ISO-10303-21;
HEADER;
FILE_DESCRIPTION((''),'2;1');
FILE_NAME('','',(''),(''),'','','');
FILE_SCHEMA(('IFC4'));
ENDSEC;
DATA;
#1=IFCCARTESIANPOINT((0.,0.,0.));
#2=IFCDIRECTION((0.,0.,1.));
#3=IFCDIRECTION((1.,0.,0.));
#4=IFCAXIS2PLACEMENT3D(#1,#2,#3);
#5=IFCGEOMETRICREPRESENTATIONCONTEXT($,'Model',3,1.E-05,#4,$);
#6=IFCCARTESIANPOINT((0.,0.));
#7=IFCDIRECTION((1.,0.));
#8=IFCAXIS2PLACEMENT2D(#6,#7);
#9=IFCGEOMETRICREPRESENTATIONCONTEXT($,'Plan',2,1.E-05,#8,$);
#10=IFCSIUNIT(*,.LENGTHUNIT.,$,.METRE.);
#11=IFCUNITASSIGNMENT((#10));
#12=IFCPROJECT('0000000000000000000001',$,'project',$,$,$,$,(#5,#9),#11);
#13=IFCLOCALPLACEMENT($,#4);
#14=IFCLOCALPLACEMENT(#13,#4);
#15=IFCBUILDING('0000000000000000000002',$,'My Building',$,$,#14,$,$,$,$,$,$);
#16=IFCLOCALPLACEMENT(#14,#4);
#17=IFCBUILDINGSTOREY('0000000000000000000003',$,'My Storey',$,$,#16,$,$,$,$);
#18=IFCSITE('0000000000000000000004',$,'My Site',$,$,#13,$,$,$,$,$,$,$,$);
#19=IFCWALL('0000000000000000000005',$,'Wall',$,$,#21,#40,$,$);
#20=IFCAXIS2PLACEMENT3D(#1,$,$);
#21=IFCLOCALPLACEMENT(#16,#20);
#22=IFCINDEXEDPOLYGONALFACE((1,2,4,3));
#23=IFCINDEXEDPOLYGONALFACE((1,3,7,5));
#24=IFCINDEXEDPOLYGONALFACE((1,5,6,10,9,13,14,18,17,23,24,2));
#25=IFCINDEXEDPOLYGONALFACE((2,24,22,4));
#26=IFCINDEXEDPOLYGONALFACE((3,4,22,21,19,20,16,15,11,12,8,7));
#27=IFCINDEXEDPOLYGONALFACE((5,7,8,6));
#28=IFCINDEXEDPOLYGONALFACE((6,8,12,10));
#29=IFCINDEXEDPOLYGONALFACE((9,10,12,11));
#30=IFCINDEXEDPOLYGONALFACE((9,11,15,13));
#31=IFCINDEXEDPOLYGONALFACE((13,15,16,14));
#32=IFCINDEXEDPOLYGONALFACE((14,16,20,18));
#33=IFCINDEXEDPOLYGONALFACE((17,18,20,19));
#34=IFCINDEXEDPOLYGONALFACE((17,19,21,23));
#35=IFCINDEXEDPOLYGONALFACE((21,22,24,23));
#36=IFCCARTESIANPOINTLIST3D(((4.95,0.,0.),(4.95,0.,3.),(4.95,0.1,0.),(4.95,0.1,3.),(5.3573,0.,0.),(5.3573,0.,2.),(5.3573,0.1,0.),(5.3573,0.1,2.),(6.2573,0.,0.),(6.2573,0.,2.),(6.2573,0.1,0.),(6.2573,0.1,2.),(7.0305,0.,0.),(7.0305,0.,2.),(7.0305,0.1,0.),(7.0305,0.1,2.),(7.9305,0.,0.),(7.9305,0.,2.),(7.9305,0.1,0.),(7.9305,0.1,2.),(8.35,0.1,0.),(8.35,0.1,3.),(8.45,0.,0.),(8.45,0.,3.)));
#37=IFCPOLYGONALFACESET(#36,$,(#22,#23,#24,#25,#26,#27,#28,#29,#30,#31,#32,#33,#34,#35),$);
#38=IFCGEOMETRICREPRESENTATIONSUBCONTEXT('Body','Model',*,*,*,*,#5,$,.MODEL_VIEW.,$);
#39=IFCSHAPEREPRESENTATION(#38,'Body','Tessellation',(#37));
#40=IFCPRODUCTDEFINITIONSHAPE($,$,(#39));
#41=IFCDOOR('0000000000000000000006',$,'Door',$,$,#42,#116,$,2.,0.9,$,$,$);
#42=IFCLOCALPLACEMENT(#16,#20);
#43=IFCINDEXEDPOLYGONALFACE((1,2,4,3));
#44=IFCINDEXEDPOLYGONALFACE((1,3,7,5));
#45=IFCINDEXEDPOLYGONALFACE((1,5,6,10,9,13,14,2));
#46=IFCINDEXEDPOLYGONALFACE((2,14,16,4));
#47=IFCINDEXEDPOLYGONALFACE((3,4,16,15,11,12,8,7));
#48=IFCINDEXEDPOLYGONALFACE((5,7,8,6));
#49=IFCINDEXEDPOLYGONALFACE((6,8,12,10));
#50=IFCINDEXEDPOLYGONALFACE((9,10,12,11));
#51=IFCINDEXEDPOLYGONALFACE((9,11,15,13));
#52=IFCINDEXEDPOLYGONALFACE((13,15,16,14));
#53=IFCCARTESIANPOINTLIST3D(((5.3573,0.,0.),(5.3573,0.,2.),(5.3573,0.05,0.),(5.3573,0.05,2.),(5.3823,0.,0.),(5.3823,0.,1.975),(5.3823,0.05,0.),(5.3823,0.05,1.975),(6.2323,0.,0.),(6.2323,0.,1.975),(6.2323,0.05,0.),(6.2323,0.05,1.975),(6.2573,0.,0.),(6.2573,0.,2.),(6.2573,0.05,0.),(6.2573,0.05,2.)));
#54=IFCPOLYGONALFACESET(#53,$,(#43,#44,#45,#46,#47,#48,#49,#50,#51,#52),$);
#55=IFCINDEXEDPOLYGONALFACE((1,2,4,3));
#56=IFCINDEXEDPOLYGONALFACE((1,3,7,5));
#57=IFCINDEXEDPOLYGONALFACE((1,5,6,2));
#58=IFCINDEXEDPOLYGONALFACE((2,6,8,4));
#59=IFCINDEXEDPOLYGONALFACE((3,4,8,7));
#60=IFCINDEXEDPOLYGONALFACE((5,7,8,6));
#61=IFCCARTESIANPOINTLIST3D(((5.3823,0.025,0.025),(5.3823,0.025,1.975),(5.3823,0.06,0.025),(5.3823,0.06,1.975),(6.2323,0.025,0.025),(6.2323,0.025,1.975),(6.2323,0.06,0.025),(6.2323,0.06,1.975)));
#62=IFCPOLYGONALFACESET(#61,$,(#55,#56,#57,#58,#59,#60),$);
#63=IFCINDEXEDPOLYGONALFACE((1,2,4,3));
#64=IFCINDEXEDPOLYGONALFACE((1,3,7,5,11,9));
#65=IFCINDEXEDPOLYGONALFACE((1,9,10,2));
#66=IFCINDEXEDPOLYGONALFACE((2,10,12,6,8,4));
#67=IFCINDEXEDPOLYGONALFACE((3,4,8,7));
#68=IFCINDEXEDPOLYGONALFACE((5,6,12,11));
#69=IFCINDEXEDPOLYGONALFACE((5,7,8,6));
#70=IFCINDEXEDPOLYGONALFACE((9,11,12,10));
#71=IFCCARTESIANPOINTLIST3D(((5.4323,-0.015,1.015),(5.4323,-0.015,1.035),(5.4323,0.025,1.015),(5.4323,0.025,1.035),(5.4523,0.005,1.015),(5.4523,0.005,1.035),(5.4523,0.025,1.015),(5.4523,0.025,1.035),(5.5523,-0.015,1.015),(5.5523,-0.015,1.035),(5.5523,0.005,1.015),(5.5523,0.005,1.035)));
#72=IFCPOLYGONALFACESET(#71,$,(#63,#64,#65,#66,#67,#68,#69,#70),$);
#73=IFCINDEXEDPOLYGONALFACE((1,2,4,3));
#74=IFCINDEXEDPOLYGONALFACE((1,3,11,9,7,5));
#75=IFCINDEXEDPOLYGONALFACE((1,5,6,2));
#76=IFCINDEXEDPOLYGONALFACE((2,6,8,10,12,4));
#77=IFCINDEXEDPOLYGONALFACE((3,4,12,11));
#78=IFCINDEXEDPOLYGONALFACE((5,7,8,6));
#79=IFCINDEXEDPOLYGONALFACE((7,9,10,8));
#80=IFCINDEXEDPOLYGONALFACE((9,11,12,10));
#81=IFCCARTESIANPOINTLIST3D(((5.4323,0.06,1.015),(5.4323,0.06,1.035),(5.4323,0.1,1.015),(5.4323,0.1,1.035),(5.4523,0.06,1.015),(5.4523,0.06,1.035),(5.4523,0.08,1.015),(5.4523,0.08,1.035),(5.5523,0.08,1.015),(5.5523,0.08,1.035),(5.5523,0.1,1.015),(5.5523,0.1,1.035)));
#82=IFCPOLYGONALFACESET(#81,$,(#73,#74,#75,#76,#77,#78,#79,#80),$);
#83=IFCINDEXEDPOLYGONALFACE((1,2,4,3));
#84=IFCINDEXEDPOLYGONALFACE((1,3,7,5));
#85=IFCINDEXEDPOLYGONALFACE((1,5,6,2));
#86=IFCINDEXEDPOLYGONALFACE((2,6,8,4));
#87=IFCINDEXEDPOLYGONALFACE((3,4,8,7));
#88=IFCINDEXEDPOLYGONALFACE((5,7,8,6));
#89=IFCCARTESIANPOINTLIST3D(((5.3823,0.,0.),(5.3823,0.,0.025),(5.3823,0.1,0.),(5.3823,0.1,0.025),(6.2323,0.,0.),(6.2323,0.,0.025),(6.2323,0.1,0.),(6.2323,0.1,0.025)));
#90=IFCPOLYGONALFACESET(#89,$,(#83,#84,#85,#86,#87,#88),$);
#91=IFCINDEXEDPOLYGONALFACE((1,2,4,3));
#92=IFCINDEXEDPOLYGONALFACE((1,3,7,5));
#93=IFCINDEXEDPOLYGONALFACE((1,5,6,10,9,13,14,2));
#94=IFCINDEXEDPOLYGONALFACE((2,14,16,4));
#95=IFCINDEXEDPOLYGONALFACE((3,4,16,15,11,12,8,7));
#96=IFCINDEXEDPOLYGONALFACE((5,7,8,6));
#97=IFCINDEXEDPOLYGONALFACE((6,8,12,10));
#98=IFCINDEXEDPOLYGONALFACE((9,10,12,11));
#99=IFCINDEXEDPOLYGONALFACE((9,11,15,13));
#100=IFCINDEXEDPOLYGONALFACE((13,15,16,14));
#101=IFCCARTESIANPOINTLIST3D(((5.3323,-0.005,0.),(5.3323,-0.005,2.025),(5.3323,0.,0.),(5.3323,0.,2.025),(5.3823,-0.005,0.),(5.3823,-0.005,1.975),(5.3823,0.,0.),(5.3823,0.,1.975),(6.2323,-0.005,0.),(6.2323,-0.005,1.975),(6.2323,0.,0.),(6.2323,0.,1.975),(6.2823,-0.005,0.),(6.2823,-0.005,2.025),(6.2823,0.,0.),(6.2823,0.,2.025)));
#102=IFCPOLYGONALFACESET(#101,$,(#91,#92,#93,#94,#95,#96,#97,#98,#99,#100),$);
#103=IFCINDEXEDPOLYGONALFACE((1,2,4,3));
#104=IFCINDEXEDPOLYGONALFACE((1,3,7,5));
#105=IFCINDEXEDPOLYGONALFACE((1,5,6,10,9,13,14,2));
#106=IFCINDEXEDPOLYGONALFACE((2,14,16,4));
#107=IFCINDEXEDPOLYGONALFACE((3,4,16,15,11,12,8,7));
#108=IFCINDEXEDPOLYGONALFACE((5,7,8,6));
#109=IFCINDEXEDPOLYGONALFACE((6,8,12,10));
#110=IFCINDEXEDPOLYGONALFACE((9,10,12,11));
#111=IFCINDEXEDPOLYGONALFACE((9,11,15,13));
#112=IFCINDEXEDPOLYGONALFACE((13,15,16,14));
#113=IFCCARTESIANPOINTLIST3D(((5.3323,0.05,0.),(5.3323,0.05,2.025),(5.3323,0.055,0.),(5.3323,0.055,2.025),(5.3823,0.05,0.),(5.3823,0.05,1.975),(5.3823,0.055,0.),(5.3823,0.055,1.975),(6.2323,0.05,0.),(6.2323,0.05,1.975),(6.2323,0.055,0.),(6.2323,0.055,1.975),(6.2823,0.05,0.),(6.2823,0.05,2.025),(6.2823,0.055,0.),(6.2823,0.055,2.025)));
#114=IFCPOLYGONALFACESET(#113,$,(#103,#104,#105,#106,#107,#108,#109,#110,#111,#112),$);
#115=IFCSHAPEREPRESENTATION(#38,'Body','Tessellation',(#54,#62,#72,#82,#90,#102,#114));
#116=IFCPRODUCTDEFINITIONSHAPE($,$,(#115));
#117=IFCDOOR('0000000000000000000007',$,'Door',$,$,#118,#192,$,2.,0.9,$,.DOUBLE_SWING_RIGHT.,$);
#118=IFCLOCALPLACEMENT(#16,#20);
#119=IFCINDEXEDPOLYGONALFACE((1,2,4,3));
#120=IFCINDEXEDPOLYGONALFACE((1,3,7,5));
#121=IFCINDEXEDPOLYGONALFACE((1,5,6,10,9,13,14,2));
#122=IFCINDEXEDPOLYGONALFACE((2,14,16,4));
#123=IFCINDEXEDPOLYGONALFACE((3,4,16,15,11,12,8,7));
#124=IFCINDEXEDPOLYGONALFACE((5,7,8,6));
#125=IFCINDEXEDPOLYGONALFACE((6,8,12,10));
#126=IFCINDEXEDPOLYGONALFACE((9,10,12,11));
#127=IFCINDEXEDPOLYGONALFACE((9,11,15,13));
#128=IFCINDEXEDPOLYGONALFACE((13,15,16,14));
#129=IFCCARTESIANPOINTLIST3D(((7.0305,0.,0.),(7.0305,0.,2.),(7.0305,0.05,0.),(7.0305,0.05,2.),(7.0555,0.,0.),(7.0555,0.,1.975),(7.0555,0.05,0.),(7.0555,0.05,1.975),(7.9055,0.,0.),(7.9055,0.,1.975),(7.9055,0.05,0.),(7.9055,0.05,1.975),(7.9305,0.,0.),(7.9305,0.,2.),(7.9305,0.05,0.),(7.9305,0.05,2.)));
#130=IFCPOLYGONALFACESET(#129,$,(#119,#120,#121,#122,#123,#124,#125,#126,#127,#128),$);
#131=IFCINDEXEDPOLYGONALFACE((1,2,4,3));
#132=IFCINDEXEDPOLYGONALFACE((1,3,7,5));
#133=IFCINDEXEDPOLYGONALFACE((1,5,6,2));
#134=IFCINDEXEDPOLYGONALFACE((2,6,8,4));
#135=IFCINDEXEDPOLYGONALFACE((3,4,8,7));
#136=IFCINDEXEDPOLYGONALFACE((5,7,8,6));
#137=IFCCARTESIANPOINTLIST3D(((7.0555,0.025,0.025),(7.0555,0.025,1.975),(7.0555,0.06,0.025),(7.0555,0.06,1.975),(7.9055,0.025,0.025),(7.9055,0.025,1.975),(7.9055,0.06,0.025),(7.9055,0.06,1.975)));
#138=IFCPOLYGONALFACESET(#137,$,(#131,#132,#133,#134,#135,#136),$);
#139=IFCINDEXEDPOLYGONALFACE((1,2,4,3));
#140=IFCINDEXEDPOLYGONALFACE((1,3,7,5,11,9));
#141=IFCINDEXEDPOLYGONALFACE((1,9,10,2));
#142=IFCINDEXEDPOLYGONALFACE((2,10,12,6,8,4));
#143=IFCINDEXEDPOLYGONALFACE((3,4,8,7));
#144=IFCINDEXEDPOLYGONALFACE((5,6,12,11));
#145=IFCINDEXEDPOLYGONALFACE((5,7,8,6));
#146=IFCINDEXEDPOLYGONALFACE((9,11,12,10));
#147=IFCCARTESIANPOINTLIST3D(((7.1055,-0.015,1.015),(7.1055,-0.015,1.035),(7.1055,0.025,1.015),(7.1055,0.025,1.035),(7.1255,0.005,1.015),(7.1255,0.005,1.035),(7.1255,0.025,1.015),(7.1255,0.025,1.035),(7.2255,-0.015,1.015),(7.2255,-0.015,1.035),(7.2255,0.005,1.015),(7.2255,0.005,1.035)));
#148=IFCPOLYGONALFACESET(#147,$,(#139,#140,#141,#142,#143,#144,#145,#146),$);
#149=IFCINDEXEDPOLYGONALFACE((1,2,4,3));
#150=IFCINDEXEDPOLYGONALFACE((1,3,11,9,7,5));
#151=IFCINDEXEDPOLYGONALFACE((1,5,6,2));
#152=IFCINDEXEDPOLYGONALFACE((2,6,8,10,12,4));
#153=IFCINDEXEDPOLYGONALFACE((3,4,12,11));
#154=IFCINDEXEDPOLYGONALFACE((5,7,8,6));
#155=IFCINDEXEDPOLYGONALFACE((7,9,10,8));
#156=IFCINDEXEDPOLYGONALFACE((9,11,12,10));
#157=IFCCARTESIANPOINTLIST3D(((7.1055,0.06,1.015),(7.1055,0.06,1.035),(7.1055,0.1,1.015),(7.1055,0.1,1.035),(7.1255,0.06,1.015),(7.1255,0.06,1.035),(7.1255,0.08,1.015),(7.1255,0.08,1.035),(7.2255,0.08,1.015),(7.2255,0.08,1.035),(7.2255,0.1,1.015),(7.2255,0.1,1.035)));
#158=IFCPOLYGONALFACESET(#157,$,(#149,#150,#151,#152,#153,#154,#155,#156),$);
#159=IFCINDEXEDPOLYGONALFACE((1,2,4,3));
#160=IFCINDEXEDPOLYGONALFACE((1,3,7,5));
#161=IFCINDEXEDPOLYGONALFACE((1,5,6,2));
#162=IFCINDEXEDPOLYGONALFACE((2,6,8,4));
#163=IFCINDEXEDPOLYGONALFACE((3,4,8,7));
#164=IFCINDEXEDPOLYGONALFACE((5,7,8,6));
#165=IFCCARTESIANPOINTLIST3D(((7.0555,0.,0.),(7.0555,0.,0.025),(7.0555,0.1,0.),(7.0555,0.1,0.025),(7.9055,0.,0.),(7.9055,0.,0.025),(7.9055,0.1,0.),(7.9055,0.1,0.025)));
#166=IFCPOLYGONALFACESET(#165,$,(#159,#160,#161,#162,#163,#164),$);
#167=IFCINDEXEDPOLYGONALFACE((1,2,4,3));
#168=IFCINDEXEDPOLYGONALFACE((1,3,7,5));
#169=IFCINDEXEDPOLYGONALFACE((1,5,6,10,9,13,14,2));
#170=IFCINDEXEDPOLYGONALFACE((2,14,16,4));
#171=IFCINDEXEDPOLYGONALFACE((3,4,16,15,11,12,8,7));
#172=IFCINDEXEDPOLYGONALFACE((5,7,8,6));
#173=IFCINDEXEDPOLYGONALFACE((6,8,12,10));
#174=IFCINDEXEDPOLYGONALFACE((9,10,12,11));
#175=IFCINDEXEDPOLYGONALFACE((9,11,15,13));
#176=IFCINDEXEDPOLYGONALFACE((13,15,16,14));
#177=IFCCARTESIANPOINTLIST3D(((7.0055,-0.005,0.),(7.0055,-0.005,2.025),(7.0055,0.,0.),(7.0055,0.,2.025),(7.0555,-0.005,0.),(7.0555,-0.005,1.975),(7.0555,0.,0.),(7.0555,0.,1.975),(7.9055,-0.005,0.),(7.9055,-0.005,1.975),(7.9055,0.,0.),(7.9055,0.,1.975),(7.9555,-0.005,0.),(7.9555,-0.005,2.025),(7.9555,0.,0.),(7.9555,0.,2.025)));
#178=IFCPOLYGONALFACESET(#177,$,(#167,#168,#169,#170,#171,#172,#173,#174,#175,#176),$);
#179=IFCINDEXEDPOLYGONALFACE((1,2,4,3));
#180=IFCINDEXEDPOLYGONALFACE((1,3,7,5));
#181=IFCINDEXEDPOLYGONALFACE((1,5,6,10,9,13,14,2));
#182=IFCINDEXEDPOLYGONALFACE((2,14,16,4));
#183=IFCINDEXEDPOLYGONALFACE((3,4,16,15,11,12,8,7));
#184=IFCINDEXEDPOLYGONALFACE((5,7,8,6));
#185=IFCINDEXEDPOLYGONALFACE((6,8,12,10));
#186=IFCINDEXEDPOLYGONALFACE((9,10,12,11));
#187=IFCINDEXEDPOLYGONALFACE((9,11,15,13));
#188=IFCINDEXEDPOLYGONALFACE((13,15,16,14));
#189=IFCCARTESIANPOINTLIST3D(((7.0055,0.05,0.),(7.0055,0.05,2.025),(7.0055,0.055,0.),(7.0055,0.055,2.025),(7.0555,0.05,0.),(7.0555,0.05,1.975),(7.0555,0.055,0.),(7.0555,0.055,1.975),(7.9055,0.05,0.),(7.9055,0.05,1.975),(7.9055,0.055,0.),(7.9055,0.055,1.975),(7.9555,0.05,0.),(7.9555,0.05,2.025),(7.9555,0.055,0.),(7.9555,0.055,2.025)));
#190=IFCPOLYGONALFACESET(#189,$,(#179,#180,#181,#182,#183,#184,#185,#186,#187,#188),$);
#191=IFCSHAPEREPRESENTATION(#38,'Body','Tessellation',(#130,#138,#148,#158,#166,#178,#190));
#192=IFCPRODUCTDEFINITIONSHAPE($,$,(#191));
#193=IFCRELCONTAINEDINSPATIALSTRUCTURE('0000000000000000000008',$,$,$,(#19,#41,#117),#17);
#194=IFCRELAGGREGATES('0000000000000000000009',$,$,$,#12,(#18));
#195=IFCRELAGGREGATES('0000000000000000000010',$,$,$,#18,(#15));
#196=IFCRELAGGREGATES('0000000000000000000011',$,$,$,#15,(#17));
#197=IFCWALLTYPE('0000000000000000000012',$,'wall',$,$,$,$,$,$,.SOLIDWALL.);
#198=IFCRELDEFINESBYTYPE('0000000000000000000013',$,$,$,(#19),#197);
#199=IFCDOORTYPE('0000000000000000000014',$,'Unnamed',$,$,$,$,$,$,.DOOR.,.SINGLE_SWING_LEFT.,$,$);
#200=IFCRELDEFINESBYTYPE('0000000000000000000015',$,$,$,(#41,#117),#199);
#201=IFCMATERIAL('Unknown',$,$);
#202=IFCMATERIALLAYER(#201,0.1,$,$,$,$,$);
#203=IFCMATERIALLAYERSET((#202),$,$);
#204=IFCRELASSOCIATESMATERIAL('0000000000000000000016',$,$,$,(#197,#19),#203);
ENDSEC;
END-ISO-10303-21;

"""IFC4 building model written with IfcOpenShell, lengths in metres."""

from ifc_helpers import new_model, entity, si_unit, frame, origin_with_axes, origin_2d_with_axis, place, context, subcontext, project, spatial, line, indexed_curve, outline, extrude, shape, source, transform, mapped, material, layer, layer_set, layer_usage, type_object, type_shapes, element, fill, save


model = new_model("IFC4")

# Units and contexts
model_context = context("Model", 3, precision=1e-05, world=origin_with_axes())
plan_context = context("Plan", 2, precision=1e-05, world=origin_2d_with_axis())
body_context_1 = subcontext(model_context, "Body", "Model", "MODEL_VIEW")
body_context_2 = subcontext(plan_context, "Body", "Plan", "PLAN_VIEW")
ifc_project = project(units=[si_unit("LENGTHUNIT", "METRE")], contexts=[model_context, plan_context])

# Site, building, storey
site_placement = place(None, origin_with_axes())
site = spatial("IfcSite", under=ifc_project, at=site_placement, Name="My Site")
building_placement = place(site_placement, origin_with_axes())
building = spatial("IfcBuilding", under=site, at=building_placement, Name="My Building")
storey_placement = place(building_placement, origin_with_axes())
storey = spatial("IfcBuildingStorey", under=building, at=storey_placement, Name="My Storey")

# Shared definitions
ifc_material = material(Name="Unknown")

# Shared definitions
ifc_layer_1 = layer(ifc_material, 0.1)
ifc_layer_set_1 = layer_set([ifc_layer_1])
wall_type = type_object("IfcWallType", Name="wall", PredefinedType="SOLIDWALL", material=ifc_layer_set_1)

# Wall, openings, doors
ifc_layer_usage_1 = layer_usage(ifc_layer_set_1, "AXIS2", "POSITIVE", 0.0)
wall_1_placement = place(storey_placement, frame((4.95, 0.0, 0.0), z_axis=(0.0, 0.0, 1.0), x_axis=(1.0, 0.0, 0.0)))
wall_1 = element("IfcWall", 1, at=wall_1_placement, inside=storey, type_object=wall_type, material=ifc_layer_usage_1, Name="Wall", context=body_context_1, shape_type="SweptSolid", body=[
    extrude(outline(indexed_curve([(0.0, 0.0), (0.0, 0.1), (3.4, 0.1), (3.5, 0.0)], segments=[line(1, 2, 3, 4, 1)])), origin_with_axes(), (0.0, 0.0, 1.0), 3.0),
])
shared_shape_1 = source(origin_with_axes(), body_context_1, "Body", "SweptSolid", [
    extrude(outline(indexed_curve([(0.0, 0.0), (0.9, 0.0), (0.9, 2.0), (0.0, 2.0)], segments=[line(1, 2, 3, 4, 1)])), frame((0.0, -0.6, 0.0), z_axis=(0.0, -1.0, 0.0), x_axis=(1.0, 0.0, 0.0)), (0.0, 0.0, -1.0), 1.2),
])
opening_1_placement = place(wall_1_placement, frame((0.4073, 0.0, 0.0), z_axis=(0.0, 0.0, 1.0), x_axis=(1.0, 0.0, 0.0)))
opening_1 = element("IfcOpeningElement", 2, at=opening_1_placement, cuts=wall_1, PredefinedType="OPENING", context=body_context_1, shape_type="MappedRepresentation", body=[
    mapped(shared_shape_1, transform((0.0, 0.0, 0.0), x_axis=(1.0, 0.0, 0.0), y_axis=(0.0, 1.0, 0.0), z_axis=(0.0, 0.0, 1.0), scale=1.0)),
])
opening_2_placement = place(wall_1_placement, frame((2.0805, 0.0, 0.0), z_axis=(0.0, 0.0, 1.0), x_axis=(1.0, 0.0, 0.0)))
opening_2 = element("IfcOpeningElement", 3, at=opening_2_placement, cuts=wall_1, PredefinedType="OPENING", context=body_context_1, shape_type="MappedRepresentation", body=[
    mapped(shared_shape_1, transform((0.0, 0.0, 0.0), x_axis=(1.0, 0.0, 0.0), y_axis=(0.0, 1.0, 0.0), z_axis=(0.0, 0.0, 1.0), scale=1.0)),
])
door_type = type_object("IfcDoorType", Name="Unnamed", OperationType="SINGLE_SWING_LEFT", PredefinedType="DOOR")
shared_shape_2 = source(origin_with_axes(), body_context_1, "Body", "SweptSolid", [
    extrude(outline(indexed_curve([(0.0, 0.0), (0.0, 2.0), (0.9, 2.0), (0.9, 0.0), (0.875, 0.0), (0.875, 1.975), (0.025, 1.975), (0.025, 0.0)], segments=[line(1, 2, 3, 4, 5, 6, 7, 8, 1)])), frame((0.0, 0.0, 0.0), z_axis=(0.0, -1.0, 0.0), x_axis=(1.0, 0.0, 0.0)), (0.0, 0.0, -1.0), 0.05),
    extrude(outline(indexed_curve([(0.0, 0.0), (0.85, 0.0), (0.85, 0.035), (0.0, 0.035)], segments=[line(1, 2, 3, 4, 1)])), frame((0.025, 0.025, 0.025), z_axis=(0.0, 0.0, 1.0), x_axis=(1.0, 0.0, 0.0)), (0.0, 0.0, 1.0), 1.95),
    extrude(outline(indexed_curve([(0.0, 0.0), (0.0, -0.04), (0.12, -0.04), (0.12, -0.02), (0.02, -0.02), (0.02, 0.0)], segments=[line(1, 2, 3, 4, 5, 6, 1)])), frame((0.075, 0.025, 1.015), z_axis=(0.0, 0.0, 1.0), x_axis=(1.0, 0.0, 0.0)), (0.0, 0.0, 1.0), 0.02),
    extrude(outline(indexed_curve([(0.0, 0.0), (0.0, 0.04), (0.12, 0.04), (0.12, 0.02), (0.02, 0.02), (0.02, 0.0)], segments=[line(1, 2, 3, 4, 5, 6, 1)])), frame((0.075, 0.06, 1.015), z_axis=(0.0, 0.0, 1.0), x_axis=(1.0, 0.0, 0.0)), (0.0, 0.0, 1.0), 0.02),
    extrude(outline(indexed_curve([(0.0, 0.0), (0.85, 0.0), (0.85, 0.1), (0.0, 0.1)], segments=[line(1, 2, 3, 4, 1)])), frame((0.025, 0.0, 0.0), z_axis=(0.0, 0.0, 1.0), x_axis=(1.0, 0.0, 0.0)), (0.0, 0.0, 1.0), 0.025),
    extrude(outline(indexed_curve([(0.0, 0.0), (0.0, 2.025), (0.95, 2.025), (0.95, 0.0), (0.9, 0.0), (0.9, 1.975), (0.05, 1.975), (0.05, 0.0)], segments=[line(1, 2, 3, 4, 5, 6, 7, 8, 1)])), frame((-0.025, -0.005, 0.0), z_axis=(0.0, -1.0, 0.0), x_axis=(1.0, 0.0, 0.0)), (0.0, 0.0, -1.0), 0.005),
    extrude(outline(indexed_curve([(0.0, 0.0), (0.0, 2.025), (0.95, 2.025), (0.95, 0.0), (0.9, 0.0), (0.9, 1.975), (0.05, 1.975), (0.05, 0.0)], segments=[line(1, 2, 3, 4, 5, 6, 7, 8, 1)])), frame((-0.025, 0.05, 0.0), z_axis=(0.0, -1.0, 0.0), x_axis=(1.0, 0.0, 0.0)), (0.0, 0.0, -1.0), 0.005),
])
shared_shape_3 = source(origin_with_axes(), body_context_2, "Body", "Curve2D", [
    entity("IfcIndexedPolyCurve", entity("IfcCartesianPointList2D", [[0.0, 0.0], [0.025, 0.0], [0.025, 0.05], [0.0, 0.05]]), [entity("IfcLineIndex", [1, 2, 3, 4, 1])]),
    entity("IfcIndexedPolyCurve", entity("IfcCartesianPointList2D", [[0.9, 0.0], [0.875, 0.0], [0.875, 0.05], [0.9, 0.05]]), [entity("IfcLineIndex", [1, 2, 3, 4, 1])]),
    entity("IfcIndexedPolyCurve", entity("IfcCartesianPointList2D", [[0.875, 0.05], [0.875, -0.8], [0.84, -0.8]])),
    entity("IfcTrimmedCurve", entity("IfcEllipse", entity("IfcAxis2Placement2D", entity("IfcCartesianPoint", [0.84, 0.05]), entity("IfcDirection", [1.0, 0.0])), 0.815, 0.85), [entity("IfcCartesianPoint", [0.84, 0.9])], [entity("IfcCartesianPoint", [0.84, -0.8])], True, "CARTESIAN"),
    entity("IfcIndexedPolyCurve", entity("IfcCartesianPointList2D", [[0.875, 0.05], [0.84, 0.05], [0.84, 0.9], [0.875, 0.9]]), [entity("IfcLineIndex", [1, 2, 3, 4, 1])]),
])
type_shapes(door_type, [shared_shape_2, shared_shape_3])
door_1_placement = place(opening_1_placement, frame((0.0, 0.0, 0.0), z_axis=(0.0, 0.0, 1.0), x_axis=(1.0, 0.0, 0.0)))
door_1 = element("IfcDoor", 4, at=door_1_placement, inside=storey, type_object=door_type, Name="Door", OverallHeight=2.0, OverallWidth=0.9, shapes=[
    shape(body_context_1, "Body", "MappedRepresentation", [mapped(shared_shape_2, transform((0.0, 0.0, 0.0), x_axis=(1.0, 0.0, 0.0), y_axis=(0.0, 1.0, 0.0), z_axis=(0.0, 0.0, 1.0), scale=1.0))]),
    shape(body_context_2, "Body", "MappedRepresentation", [mapped(shared_shape_3, transform((0.0, 0.0, 0.0), x_axis=(1.0, 0.0, 0.0), y_axis=(0.0, 1.0, 0.0), z_axis=(0.0, 0.0, 1.0), scale=1.0))]),
])
fill(opening_1, door_1)
door_2_placement = place(opening_2_placement, origin_with_axes())
door_2 = element("IfcDoor", 5, at=door_2_placement, inside=storey, type_object=door_type, Name="Door", OperationType="DOUBLE_SWING_RIGHT", OverallHeight=2.0, OverallWidth=0.9, shapes=[
    shape(body_context_1, "Body", "MappedRepresentation", [mapped(shared_shape_2, transform((0.0, 0.0, 0.0), x_axis=(1.0, 0.0, 0.0), y_axis=(0.0, 1.0, 0.0), z_axis=(0.0, 0.0, 1.0), scale=1.0))]),
    shape(body_context_2, "Body", "MappedRepresentation", [mapped(shared_shape_3, transform((0.0, 0.0, 0.0), x_axis=(1.0, 0.0, 0.0), y_axis=(0.0, 1.0, 0.0), z_axis=(0.0, 0.0, 1.0), scale=1.0))]),
])
fill(opening_2, door_2)

save(model, "model.ifc")
